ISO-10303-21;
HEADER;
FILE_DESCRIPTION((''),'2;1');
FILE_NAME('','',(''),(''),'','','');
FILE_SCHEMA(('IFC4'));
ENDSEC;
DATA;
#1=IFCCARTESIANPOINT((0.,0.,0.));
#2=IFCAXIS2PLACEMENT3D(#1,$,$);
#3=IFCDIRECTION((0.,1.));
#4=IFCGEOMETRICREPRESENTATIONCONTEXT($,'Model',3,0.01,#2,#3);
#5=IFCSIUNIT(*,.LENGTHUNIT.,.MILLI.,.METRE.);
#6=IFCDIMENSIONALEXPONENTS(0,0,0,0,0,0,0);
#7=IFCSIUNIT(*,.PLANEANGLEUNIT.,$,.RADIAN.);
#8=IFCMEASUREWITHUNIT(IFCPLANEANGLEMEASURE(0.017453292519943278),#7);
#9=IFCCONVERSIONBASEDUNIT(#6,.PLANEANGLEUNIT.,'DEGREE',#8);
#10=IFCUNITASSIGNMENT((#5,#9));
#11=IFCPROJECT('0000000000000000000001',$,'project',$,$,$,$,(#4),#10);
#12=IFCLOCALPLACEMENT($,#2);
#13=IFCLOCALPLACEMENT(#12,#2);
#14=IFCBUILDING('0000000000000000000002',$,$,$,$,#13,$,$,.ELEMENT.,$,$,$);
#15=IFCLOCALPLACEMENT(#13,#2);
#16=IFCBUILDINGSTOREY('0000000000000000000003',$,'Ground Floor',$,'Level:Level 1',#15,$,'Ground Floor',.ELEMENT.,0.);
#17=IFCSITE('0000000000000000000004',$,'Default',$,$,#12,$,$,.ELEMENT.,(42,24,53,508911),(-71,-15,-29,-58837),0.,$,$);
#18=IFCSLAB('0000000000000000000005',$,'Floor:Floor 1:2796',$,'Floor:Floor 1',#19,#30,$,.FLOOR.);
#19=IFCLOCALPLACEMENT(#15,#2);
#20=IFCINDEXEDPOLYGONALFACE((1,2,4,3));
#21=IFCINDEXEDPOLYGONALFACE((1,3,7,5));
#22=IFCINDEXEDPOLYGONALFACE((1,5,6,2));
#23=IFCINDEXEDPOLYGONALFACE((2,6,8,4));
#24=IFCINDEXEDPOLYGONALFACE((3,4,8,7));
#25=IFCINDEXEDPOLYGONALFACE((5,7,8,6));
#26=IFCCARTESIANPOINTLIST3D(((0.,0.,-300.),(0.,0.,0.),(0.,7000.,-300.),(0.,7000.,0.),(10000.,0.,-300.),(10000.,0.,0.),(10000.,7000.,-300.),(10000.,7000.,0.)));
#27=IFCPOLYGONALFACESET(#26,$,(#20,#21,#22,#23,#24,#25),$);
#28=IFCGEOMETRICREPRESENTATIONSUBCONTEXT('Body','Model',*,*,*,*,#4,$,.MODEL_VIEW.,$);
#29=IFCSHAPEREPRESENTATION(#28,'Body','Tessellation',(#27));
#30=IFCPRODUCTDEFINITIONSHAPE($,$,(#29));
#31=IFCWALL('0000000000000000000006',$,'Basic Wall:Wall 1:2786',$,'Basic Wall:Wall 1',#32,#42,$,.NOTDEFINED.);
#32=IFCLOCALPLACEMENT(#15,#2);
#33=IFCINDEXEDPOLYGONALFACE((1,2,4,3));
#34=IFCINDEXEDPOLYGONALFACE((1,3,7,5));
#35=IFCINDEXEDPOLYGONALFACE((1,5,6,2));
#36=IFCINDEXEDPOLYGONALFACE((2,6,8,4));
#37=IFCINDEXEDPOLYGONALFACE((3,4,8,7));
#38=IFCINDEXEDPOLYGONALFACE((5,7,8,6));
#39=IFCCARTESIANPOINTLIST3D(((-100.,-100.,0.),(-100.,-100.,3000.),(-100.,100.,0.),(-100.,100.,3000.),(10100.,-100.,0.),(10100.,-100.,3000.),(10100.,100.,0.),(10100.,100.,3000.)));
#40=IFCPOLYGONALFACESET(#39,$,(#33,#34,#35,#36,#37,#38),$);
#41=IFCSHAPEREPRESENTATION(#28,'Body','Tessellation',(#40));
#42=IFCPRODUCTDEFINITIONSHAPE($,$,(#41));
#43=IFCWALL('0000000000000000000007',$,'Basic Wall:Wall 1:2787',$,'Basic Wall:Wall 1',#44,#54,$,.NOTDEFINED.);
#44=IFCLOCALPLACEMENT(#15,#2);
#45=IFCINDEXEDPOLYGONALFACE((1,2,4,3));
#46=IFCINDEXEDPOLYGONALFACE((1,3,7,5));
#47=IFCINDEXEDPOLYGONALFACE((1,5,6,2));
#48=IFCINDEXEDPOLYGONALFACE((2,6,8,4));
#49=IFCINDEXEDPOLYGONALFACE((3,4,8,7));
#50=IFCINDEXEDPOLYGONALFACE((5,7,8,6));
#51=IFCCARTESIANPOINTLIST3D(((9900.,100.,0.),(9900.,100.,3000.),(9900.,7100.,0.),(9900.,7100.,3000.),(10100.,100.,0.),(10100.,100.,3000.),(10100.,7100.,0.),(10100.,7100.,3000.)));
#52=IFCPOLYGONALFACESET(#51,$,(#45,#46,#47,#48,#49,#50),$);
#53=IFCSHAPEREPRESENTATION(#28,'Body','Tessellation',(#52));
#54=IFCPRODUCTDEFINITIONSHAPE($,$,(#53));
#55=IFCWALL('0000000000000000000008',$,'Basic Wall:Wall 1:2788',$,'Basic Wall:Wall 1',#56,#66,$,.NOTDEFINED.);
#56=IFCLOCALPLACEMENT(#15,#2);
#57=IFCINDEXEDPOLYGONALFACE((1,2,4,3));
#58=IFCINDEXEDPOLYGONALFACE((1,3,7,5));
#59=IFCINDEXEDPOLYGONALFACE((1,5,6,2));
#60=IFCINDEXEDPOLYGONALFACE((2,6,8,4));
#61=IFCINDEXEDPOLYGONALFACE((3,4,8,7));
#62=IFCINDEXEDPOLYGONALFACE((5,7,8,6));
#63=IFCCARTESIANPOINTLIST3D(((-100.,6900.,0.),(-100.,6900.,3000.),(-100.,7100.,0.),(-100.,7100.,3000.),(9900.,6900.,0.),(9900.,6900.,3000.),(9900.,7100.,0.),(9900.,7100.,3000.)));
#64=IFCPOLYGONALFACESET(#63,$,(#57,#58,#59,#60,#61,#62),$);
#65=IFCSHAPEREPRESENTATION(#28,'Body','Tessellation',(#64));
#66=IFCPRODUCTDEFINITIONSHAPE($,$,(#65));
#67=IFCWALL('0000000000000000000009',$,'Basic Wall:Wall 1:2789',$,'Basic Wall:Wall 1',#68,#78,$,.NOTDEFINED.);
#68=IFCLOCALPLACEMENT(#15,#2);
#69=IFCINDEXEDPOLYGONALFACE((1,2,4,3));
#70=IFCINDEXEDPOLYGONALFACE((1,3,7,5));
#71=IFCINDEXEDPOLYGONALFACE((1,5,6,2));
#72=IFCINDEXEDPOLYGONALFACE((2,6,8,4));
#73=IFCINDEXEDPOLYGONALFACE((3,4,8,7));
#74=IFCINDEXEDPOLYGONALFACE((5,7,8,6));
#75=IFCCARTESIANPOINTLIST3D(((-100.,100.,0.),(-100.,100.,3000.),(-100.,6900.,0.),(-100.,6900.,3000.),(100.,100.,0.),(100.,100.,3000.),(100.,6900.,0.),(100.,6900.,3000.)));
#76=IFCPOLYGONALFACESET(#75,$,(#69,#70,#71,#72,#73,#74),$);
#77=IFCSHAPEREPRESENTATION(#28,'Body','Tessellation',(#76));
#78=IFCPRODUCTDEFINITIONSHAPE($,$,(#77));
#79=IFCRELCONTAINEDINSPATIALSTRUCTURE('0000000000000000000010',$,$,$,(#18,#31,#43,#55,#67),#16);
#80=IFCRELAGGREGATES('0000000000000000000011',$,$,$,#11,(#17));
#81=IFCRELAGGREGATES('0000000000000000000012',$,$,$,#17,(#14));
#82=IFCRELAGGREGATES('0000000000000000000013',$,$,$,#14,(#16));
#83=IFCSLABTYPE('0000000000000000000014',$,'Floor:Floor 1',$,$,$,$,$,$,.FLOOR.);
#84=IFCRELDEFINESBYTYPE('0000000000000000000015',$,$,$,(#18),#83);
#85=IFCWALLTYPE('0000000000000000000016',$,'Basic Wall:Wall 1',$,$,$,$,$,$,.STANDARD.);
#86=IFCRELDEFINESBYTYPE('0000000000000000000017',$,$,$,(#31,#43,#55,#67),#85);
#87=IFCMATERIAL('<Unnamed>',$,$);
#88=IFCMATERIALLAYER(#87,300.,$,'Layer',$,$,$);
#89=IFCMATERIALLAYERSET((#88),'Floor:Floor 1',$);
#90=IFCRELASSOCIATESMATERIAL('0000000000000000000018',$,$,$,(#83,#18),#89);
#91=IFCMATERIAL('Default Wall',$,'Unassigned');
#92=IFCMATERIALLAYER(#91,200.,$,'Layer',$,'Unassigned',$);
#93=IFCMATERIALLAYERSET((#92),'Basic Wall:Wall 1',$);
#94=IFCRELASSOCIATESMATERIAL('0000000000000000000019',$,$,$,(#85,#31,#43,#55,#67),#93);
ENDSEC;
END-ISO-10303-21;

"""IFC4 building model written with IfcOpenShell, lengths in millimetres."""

from ifc_helpers import new_model, entity, si_unit, converted_unit, direction, frame, frame_2d, origin, origin_2d_with_axis, place, context, subcontext, project, spatial, rectangle, extrude, material, layer, layer_set, layer_usage, type_object, element, save


model = new_model("IFC4")

# Units and contexts
model_context = context("Model", 3, precision=0.01, world=origin(), true_north=direction((0.0, 1.0)))
body_context = subcontext(model_context, "Body", "Model", "MODEL_VIEW")
ifc_project = project(units=[si_unit("LENGTHUNIT", "METRE", prefix="MILLI"), converted_unit("PLANEANGLEUNIT", "DEGREE", entity("IfcPlaneAngleMeasure", 0.017453292519943278), si_unit("PLANEANGLEUNIT", "RADIAN"), dimensions=[0, 0, 0, 0, 0, 0, 0])], contexts=[model_context])

# Site, building, storey
site_placement = place(None, origin())
site = spatial("IfcSite", under=ifc_project, at=site_placement, Name="Default", CompositionType="ELEMENT", RefLatitude=(42, 24, 53, 508911), RefLongitude=(-71, -15, -29, -58837), RefElevation=0.0)
building_placement = place(site_placement, origin())
building = spatial("IfcBuilding", under=site, at=building_placement, CompositionType="ELEMENT")
storey_placement = place(building_placement, origin())
storey = spatial("IfcBuildingStorey", under=building, at=storey_placement, Name="Ground Floor", ObjectType="Level:Level 1", LongName="Ground Floor", CompositionType="ELEMENT", Elevation=0.0)

# Slab
ifc_material_1 = material(Name="<Unnamed>")
ifc_layer_1 = layer(ifc_material_1, 300.0, Name="Layer")
ifc_layer_set_1 = layer_set([ifc_layer_1], Name="Floor:Floor 1")
ifc_layer_usage_1 = layer_usage(ifc_layer_set_1, "AXIS3", "POSITIVE", 0.0)
slab_type = type_object("IfcSlabType", Name="Floor:Floor 1", PredefinedType="FLOOR", material=ifc_layer_set_1)
slab_placement = place(storey_placement, origin())
element("IfcSlab", 1, at=slab_placement, inside=storey, type_object=slab_type, material=ifc_layer_usage_1, Name="Floor:Floor 1:2796", ObjectType="Floor:Floor 1", PredefinedType="FLOOR", context=body_context, shape_type="SweptSolid", body=[
    extrude(rectangle(XDim=7000.0, YDim=10000.0, at=origin_2d_with_axis()), frame((5000.0, 3500.0, 0.0), z_axis=(0.0, 0.0, -1.0), x_axis=(0.0, 1.0, 0.0)), (0.0, 0.0, 1.0), 300.0),
])

# Walls
ifc_material_2 = material(Name="Default Wall", Category="Unassigned")
ifc_layer_2 = layer(ifc_material_2, 200.0, Name="Layer", Category="Unassigned")
ifc_layer_set_2 = layer_set([ifc_layer_2], Name="Basic Wall:Wall 1")
ifc_layer_usage_2 = layer_usage(ifc_layer_set_2, "AXIS2", "NEGATIVE", 100.0)
wall_type = type_object("IfcWallType", Name="Basic Wall:Wall 1", PredefinedType="STANDARD", material=ifc_layer_set_2)
wall_1_placement = place(storey_placement, frame((-100.0, 0.0, 0.0)))
element("IfcWall", 2, at=wall_1_placement, inside=storey, type_object=wall_type, material=ifc_layer_usage_2, Name="Basic Wall:Wall 1:2786", ObjectType="Basic Wall:Wall 1", PredefinedType="NOTDEFINED", context=body_context, shape_type="SweptSolid", body=[
    extrude(rectangle(XDim=10200.0, YDim=200.0, at=frame_2d((5100.0, 0.0), x_axis=(-1.0, 0.0))), origin(), (0.0, 0.0, 1.0), 3000.0),
])
ifc_layer_usage_3 = layer_usage(ifc_layer_set_2, "AXIS2", "NEGATIVE", 100.0)
wall_2_placement = place(storey_placement, frame((10000.0, 100.0, 0.0), z_axis=(0.0, 0.0, 1.0), x_axis=(0.0, 1.0, 0.0)))
element("IfcWall", 3, at=wall_2_placement, inside=storey, type_object=wall_type, material=ifc_layer_usage_3, Name="Basic Wall:Wall 1:2787", ObjectType="Basic Wall:Wall 1", PredefinedType="NOTDEFINED", context=body_context, shape_type="SweptSolid", body=[
    extrude(rectangle(XDim=7000.0, YDim=200.0, at=frame_2d((3500.0, 0.0), x_axis=(-1.0, 0.0))), origin(), (0.0, 0.0, 1.0), 3000.0),
])
ifc_layer_usage_4 = layer_usage(ifc_layer_set_2, "AXIS2", "NEGATIVE", 100.0)
wall_3_placement = place(storey_placement, frame((9900.0, 7000.0, 0.0), z_axis=(0.0, 0.0, 1.0), x_axis=(-1.0, 0.0, 0.0)))
element("IfcWall", 4, at=wall_3_placement, inside=storey, type_object=wall_type, material=ifc_layer_usage_4, Name="Basic Wall:Wall 1:2788", ObjectType="Basic Wall:Wall 1", PredefinedType="NOTDEFINED", context=body_context, shape_type="SweptSolid", body=[
    extrude(rectangle(XDim=10000.0, YDim=200.0, at=frame_2d((5000.0, 0.0), x_axis=(-1.0, 0.0))), origin(), (0.0, 0.0, 1.0), 3000.0),
])
ifc_layer_usage_5 = layer_usage(ifc_layer_set_2, "AXIS2", "NEGATIVE", 100.0)
wall_4_placement = place(storey_placement, frame((0.0, 6900.0, 0.0), z_axis=(0.0, 0.0, 1.0), x_axis=(0.0, -1.0, 0.0)))
element("IfcWall", 5, at=wall_4_placement, inside=storey, type_object=wall_type, material=ifc_layer_usage_5, Name="Basic Wall:Wall 1:2789", ObjectType="Basic Wall:Wall 1", PredefinedType="NOTDEFINED", context=body_context, shape_type="SweptSolid", body=[
    extrude(rectangle(XDim=6800.0, YDim=200.0, at=frame_2d((3400.0, 0.0), x_axis=(-1.0, 0.0))), origin(), (0.0, 0.0, 1.0), 3000.0),
])

save(model, "model.ifc")
